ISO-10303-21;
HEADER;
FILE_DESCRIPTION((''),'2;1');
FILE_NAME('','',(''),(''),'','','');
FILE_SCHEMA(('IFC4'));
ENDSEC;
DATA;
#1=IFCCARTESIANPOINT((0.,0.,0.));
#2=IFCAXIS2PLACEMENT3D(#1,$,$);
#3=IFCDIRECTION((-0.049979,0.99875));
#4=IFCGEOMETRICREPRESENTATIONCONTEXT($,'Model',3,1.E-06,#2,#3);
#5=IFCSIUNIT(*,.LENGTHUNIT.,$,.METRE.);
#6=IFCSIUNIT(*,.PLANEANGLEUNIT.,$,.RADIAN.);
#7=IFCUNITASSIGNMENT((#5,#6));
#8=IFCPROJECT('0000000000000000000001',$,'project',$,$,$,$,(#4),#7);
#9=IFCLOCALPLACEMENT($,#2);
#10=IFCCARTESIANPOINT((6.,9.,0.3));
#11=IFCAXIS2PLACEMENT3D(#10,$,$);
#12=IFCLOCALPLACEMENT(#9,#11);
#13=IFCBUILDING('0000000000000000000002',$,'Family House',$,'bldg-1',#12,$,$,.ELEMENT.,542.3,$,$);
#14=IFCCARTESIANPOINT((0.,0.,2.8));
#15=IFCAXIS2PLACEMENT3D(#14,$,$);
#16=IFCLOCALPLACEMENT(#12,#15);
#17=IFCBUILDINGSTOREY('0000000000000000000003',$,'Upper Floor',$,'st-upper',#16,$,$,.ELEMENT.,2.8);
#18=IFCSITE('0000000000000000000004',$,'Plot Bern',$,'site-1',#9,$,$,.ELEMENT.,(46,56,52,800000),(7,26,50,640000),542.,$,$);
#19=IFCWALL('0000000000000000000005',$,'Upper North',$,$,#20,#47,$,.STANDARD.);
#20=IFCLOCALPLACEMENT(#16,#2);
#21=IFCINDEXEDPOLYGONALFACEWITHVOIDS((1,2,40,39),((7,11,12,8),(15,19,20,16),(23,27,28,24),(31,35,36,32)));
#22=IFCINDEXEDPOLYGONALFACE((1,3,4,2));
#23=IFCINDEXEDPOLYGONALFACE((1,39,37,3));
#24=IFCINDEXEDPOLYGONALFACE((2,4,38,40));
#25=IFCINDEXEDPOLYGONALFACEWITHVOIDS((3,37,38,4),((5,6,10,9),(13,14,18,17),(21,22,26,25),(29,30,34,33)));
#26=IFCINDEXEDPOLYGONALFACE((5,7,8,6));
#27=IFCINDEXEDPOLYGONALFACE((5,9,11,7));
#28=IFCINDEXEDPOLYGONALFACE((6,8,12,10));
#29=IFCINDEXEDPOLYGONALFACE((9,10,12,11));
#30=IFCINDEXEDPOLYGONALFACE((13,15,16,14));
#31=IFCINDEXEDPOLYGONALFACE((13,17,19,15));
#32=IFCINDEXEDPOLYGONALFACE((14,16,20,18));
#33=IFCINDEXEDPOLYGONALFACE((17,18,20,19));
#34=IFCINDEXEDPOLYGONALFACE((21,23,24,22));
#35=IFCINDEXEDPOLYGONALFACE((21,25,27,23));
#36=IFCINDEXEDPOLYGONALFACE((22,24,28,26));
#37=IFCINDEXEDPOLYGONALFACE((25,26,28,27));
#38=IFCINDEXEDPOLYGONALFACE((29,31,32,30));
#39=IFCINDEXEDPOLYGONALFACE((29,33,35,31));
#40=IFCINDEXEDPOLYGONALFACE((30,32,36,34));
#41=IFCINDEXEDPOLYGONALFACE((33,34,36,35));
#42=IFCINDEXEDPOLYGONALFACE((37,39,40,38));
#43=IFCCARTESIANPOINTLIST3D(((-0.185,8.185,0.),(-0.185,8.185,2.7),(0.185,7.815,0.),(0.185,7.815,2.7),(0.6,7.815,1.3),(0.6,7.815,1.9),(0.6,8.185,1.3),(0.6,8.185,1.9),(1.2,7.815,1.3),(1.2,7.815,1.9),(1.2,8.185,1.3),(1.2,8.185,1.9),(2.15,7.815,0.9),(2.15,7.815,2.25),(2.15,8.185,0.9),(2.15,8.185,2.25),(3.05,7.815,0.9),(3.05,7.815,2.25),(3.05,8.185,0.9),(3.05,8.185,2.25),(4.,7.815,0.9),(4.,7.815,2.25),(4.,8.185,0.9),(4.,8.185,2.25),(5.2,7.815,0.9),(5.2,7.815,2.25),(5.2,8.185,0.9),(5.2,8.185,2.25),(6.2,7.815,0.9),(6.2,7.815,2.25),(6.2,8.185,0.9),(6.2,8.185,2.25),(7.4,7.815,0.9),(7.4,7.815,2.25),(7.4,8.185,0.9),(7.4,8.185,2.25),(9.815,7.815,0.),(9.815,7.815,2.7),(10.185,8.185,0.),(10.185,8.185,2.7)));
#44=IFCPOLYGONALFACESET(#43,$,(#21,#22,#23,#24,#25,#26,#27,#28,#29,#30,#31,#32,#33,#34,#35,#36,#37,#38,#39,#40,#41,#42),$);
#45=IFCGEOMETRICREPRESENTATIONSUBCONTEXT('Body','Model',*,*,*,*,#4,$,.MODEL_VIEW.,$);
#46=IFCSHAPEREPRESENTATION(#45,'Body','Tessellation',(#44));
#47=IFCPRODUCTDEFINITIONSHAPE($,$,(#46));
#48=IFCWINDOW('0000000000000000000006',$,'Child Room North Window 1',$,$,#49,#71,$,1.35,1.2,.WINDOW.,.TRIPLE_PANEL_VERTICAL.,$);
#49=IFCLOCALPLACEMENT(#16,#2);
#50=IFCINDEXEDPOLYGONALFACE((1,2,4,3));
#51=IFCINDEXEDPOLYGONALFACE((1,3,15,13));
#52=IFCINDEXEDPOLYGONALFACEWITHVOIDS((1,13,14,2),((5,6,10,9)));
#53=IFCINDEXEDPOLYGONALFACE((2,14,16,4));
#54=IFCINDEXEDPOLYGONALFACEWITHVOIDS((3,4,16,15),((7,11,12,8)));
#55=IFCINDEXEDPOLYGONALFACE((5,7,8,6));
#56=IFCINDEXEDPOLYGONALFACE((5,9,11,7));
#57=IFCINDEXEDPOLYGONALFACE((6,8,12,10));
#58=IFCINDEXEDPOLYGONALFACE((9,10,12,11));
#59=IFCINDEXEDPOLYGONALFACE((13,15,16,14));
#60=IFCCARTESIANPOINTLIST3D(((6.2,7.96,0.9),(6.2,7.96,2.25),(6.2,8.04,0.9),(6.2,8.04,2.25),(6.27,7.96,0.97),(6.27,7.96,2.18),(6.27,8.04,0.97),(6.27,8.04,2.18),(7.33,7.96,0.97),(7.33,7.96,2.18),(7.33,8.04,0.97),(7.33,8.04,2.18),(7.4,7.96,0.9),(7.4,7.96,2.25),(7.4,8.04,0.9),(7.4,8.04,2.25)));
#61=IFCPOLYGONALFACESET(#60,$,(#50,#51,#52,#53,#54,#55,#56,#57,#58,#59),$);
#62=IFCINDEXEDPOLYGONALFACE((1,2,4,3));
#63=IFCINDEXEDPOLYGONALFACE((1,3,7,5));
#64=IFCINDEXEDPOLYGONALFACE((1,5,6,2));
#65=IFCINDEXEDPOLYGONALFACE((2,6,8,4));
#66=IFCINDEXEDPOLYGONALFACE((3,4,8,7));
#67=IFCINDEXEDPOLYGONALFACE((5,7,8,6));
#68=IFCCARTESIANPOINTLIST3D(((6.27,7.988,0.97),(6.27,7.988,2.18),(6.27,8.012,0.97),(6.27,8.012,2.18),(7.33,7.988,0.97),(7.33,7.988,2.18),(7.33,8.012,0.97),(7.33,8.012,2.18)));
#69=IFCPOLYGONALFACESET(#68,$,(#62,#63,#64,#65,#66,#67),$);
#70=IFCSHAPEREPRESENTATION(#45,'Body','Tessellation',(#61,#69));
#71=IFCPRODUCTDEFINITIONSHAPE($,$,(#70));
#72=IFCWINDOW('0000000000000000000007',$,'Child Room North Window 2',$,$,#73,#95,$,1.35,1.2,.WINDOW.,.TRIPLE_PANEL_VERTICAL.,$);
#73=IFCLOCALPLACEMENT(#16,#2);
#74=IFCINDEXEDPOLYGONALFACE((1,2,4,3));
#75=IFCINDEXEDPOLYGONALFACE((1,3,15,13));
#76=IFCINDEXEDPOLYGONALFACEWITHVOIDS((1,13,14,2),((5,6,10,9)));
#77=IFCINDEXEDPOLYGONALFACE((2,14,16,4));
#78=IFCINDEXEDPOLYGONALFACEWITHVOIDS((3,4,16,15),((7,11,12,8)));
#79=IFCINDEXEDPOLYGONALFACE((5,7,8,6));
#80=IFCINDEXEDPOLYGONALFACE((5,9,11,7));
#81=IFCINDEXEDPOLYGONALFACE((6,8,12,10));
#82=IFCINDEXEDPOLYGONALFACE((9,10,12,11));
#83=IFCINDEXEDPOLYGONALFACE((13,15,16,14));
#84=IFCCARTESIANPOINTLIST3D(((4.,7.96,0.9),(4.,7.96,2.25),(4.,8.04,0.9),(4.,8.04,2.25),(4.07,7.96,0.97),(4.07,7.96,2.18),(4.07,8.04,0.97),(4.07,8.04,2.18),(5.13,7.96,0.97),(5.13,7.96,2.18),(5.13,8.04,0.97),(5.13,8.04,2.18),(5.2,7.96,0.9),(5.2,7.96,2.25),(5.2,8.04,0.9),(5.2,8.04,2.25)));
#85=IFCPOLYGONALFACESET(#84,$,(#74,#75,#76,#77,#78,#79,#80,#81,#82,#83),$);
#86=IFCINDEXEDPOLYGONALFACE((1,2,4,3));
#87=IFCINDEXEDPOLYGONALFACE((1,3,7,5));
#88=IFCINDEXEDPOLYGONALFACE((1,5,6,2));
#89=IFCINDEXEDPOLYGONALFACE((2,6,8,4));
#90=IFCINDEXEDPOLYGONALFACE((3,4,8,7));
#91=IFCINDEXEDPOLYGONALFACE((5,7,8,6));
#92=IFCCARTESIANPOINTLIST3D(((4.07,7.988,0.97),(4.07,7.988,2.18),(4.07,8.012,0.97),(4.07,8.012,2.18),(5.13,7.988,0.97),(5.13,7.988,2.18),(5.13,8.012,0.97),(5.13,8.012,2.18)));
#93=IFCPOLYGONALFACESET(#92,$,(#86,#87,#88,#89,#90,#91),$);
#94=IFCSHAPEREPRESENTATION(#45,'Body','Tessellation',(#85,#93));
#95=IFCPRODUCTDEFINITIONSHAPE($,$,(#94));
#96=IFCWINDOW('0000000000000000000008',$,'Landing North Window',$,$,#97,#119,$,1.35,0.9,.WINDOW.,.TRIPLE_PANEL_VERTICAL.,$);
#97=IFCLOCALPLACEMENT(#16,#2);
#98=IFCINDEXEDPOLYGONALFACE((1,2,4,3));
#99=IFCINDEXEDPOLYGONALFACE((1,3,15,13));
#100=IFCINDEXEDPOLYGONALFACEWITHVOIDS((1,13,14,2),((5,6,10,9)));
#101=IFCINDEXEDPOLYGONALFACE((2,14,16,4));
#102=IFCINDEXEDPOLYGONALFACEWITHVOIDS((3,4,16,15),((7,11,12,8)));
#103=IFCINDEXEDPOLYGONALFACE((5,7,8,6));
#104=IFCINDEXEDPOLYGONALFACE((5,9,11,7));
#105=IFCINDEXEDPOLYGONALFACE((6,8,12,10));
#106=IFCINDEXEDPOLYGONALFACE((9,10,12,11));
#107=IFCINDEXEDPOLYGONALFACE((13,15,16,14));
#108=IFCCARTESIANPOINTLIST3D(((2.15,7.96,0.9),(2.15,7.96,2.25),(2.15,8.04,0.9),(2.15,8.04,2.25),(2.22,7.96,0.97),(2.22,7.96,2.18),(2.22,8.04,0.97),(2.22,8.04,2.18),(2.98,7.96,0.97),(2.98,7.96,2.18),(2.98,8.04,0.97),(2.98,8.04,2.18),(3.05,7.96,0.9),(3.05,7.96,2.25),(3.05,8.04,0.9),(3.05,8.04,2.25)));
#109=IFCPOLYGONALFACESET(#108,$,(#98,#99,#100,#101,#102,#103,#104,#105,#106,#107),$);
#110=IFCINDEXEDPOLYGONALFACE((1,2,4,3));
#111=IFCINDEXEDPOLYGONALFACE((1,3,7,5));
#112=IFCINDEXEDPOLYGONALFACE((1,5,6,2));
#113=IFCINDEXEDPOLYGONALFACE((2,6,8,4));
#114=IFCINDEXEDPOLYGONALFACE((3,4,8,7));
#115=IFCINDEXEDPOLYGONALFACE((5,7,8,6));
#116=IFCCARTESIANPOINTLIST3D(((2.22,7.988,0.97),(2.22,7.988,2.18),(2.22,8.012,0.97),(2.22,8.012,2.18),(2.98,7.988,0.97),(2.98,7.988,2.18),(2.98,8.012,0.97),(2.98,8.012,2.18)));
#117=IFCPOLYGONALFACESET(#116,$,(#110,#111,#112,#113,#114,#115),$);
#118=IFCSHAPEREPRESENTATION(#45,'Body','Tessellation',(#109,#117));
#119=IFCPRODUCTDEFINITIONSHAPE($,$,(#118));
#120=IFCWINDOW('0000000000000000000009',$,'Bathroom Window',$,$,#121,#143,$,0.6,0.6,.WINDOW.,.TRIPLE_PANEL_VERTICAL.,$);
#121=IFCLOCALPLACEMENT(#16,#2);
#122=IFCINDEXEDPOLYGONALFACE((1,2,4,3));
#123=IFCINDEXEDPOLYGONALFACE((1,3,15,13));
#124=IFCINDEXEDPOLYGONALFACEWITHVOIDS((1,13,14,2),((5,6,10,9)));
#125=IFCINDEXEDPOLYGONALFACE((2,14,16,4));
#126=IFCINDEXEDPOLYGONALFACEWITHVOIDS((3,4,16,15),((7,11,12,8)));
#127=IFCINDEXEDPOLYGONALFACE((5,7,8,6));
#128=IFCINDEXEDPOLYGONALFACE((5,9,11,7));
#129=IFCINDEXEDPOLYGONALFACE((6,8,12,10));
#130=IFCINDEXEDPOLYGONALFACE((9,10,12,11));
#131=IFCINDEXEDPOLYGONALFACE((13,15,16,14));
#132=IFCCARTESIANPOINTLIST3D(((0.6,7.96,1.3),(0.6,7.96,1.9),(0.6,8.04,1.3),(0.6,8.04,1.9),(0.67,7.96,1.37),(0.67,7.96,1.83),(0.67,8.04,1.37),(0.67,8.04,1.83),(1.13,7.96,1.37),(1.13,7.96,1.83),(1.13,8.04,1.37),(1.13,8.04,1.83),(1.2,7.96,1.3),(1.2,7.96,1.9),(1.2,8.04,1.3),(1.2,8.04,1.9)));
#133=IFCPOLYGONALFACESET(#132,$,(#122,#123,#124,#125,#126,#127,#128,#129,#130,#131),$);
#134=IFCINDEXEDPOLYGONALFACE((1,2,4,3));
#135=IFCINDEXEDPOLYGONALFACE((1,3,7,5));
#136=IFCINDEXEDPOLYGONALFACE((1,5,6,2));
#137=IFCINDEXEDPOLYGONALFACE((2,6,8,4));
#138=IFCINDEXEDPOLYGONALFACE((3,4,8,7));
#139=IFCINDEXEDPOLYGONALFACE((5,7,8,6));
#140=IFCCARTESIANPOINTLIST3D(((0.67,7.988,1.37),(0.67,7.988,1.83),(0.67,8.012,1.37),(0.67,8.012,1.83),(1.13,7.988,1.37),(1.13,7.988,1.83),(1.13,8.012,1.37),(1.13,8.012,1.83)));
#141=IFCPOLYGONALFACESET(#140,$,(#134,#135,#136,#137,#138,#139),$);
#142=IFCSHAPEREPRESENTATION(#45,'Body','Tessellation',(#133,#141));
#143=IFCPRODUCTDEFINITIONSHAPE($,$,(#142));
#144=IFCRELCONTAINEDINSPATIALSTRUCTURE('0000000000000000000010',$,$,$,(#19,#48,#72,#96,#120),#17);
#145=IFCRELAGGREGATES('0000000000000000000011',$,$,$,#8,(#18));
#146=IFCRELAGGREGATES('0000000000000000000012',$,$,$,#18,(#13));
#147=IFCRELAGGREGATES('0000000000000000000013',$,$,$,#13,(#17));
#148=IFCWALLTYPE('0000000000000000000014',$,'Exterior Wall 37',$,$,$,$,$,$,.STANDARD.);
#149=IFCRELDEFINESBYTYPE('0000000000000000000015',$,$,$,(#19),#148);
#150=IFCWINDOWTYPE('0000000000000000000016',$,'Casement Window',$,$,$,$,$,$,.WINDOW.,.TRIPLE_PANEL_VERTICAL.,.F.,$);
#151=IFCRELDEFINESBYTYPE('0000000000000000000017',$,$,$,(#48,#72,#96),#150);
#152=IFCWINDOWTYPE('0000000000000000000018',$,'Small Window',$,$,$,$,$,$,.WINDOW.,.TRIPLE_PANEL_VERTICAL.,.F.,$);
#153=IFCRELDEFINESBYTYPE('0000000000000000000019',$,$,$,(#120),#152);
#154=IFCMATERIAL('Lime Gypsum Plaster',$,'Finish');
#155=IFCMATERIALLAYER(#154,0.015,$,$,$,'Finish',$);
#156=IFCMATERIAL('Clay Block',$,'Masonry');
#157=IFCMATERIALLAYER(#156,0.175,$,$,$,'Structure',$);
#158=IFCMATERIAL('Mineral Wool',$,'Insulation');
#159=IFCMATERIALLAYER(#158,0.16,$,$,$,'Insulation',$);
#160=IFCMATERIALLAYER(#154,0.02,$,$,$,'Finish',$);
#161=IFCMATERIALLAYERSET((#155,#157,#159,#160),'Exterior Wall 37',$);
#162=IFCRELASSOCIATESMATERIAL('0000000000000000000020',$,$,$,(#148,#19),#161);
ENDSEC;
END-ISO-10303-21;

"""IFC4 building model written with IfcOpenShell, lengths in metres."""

from ifc_helpers import new_model, si_unit, direction, frame, frame_2d, origin, origin_2d, place, context, subcontext, project, spatial, polyline, rectangle, outline, extrude, material, layer, layer_set, layer_usage, type_object, element, fill, save


model = new_model("IFC4")

# Units and contexts
model_context = context("Model", 3, precision=1e-06, world=origin(), true_north=direction((-0.049979, 0.99875)))
body_context = subcontext(model_context, "Body", "Model", "MODEL_VIEW")
ifc_project = project(units=[si_unit("LENGTHUNIT", "METRE"), si_unit("PLANEANGLEUNIT", "RADIAN")], contexts=[model_context])

# Site, building, storey
site_placement = place(None, origin())
site = spatial("IfcSite", under=ifc_project, at=site_placement, Name="Plot Bern", ObjectType="site-1", CompositionType="ELEMENT", RefLatitude=(46, 56, 52, 800000), RefLongitude=(7, 26, 50, 640000), RefElevation=542.0)
building_placement = place(site_placement, frame((6.0, 9.0, 0.3)))
building = spatial("IfcBuilding", under=site, at=building_placement, Name="Family House", ObjectType="bldg-1", CompositionType="ELEMENT", ElevationOfRefHeight=542.3)
storey_placement = place(building_placement, frame((0.0, 0.0, 2.8)))
storey = spatial("IfcBuildingStorey", under=building, at=storey_placement, Name="Upper Floor", ObjectType="st-upper", CompositionType="ELEMENT", Elevation=2.8)

# Shared definitions
ifc_material_1 = material(Name="Mineral Wool", Category="Insulation")

# Shared definitions
ifc_material_2 = material(Name="Lime Gypsum Plaster", Category="Finish")
ifc_layer_1 = layer(ifc_material_2, 0.015, Category="Finish")
ifc_material_3 = material(Name="Clay Block", Category="Masonry")
ifc_layer_2 = layer(ifc_material_3, 0.175, Category="Structure")
ifc_layer_3 = layer(ifc_material_1, 0.16, Category="Insulation")
ifc_layer_4 = layer(ifc_material_2, 0.02, Category="Finish")
ifc_layer_set_1 = layer_set([ifc_layer_1, ifc_layer_2, ifc_layer_3, ifc_layer_4], Name="Exterior Wall 37")
wall_type_1 = type_object("IfcWallType", Name="Exterior Wall 37", PredefinedType="STANDARD", material=ifc_layer_set_1)

# Shared definitions
window_type_1 = type_object("IfcWindowType", Name="Casement Window", ParameterTakesPrecedence=False, PartitioningType="TRIPLE_PANEL_VERTICAL", PredefinedType="WINDOW")

# Wall, openings, windows
ifc_layer_usage_1 = layer_usage(ifc_layer_set_1, "AXIS2", "NEGATIVE", 0.185)
wall_1_placement = place(storey_placement, origin())
wall_1 = element("IfcWall", 1, at=wall_1_placement, inside=storey, type_object=wall_type_1, material=ifc_layer_usage_1, Name="Upper North", PredefinedType="STANDARD", context=body_context, shape_type="SweptSolid", body=[
    extrude(outline(polyline([(10.185, 8.185), (-0.185, 8.185), (0.185, 7.815), (9.815, 7.815), (10.185, 8.185)])), origin(), (0.0, 0.0, 1.0), 2.7),
])
opening_1_placement = place(wall_1_placement, frame((0.9, 8.0, 1.3), z_axis=(0.0, 0.0, 1.0), x_axis=(-1.0, 0.0, 0.0)))
opening_1 = element("IfcOpeningElement", 2, at=opening_1_placement, cuts=wall_1, PredefinedType="OPENING", context=body_context, shape_type="SweptSolid", body=[
    extrude(rectangle(XDim=0.6, YDim=0.37, at=origin_2d()), origin(), (0.0, 0.0, 1.0), 0.6),
])
opening_2_placement = place(wall_1_placement, frame((6.8, 8.0, 0.9), z_axis=(0.0, 0.0, 1.0), x_axis=(-1.0, 0.0, 0.0)))
opening_2 = element("IfcOpeningElement", 3, at=opening_2_placement, cuts=wall_1, PredefinedType="OPENING", context=body_context, shape_type="SweptSolid", body=[
    extrude(rectangle(XDim=1.2, YDim=0.37, at=origin_2d()), origin(), (0.0, 0.0, 1.0), 1.35),
])
opening_3_placement = place(wall_1_placement, frame((4.6, 8.0, 0.9), z_axis=(0.0, 0.0, 1.0), x_axis=(-1.0, 0.0, 0.0)))
opening_3 = element("IfcOpeningElement", 4, at=opening_3_placement, cuts=wall_1, PredefinedType="OPENING", context=body_context, shape_type="SweptSolid", body=[
    extrude(rectangle(XDim=1.2, YDim=0.37, at=origin_2d()), origin(), (0.0, 0.0, 1.0), 1.35),
])
opening_4_placement = place(wall_1_placement, frame((2.6, 8.0, 0.9), z_axis=(0.0, 0.0, 1.0), x_axis=(-1.0, 0.0, 0.0)))
opening_4 = element("IfcOpeningElement", 5, at=opening_4_placement, cuts=wall_1, PredefinedType="OPENING", context=body_context, shape_type="SweptSolid", body=[
    extrude(rectangle(XDim=0.9, YDim=0.37, at=origin_2d()), origin(), (0.0, 0.0, 1.0), 1.35),
])
window_1_placement = place(opening_2_placement, frame((0.0, 0.0, 0.0), z_axis=(0.0, -1.0, 0.0), x_axis=(1.0, 0.0, 0.0)))
window_1 = element("IfcWindow", 6, at=window_1_placement, inside=storey, type_object=window_type_1, Name="Child Room North Window 1", OverallHeight=1.35, OverallWidth=1.2, PartitioningType="TRIPLE_PANEL_VERTICAL", PredefinedType="WINDOW", context=body_context, shape_type="SweptSolid", body=[
    extrude(outline(polyline([(-0.6, 0.0), (0.6, 0.0), (0.6, 1.35), (-0.6, 1.35), (-0.6, 0.0)]), holes=[polyline([(-0.53, 0.07), (0.53, 0.07), (0.53, 1.28), (-0.53, 1.28), (-0.53, 0.07)])]), frame((0.0, 0.0, -0.04)), (0.0, 0.0, 1.0), 0.08),
    extrude(rectangle(XDim=1.06, YDim=1.21, at=frame_2d((0.0, 0.675))), frame((0.0, 0.0, -0.012)), (0.0, 0.0, 1.0), 0.024),
])
fill(opening_2, window_1)
window_2_placement = place(opening_3_placement, frame((0.0, 0.0, 0.0), z_axis=(0.0, -1.0, 0.0), x_axis=(1.0, 0.0, 0.0)))
window_2 = element("IfcWindow", 7, at=window_2_placement, inside=storey, type_object=window_type_1, Name="Child Room North Window 2", OverallHeight=1.35, OverallWidth=1.2, PartitioningType="TRIPLE_PANEL_VERTICAL", PredefinedType="WINDOW", context=body_context, shape_type="SweptSolid", body=[
    extrude(outline(polyline([(-0.6, 0.0), (0.6, 0.0), (0.6, 1.35), (-0.6, 1.35), (-0.6, 0.0)]), holes=[polyline([(-0.53, 0.07), (0.53, 0.07), (0.53, 1.28), (-0.53, 1.28), (-0.53, 0.07)])]), frame((0.0, 0.0, -0.04)), (0.0, 0.0, 1.0), 0.08),
    extrude(rectangle(XDim=1.06, YDim=1.21, at=frame_2d((0.0, 0.675))), frame((0.0, 0.0, -0.012)), (0.0, 0.0, 1.0), 0.024),
])
fill(opening_3, window_2)
window_3_placement = place(opening_4_placement, frame((0.0, 0.0, 0.0), z_axis=(0.0, -1.0, 0.0), x_axis=(1.0, 0.0, 0.0)))
window_3 = element("IfcWindow", 8, at=window_3_placement, inside=storey, type_object=window_type_1, Name="Landing North Window", OverallHeight=1.35, OverallWidth=0.9, PartitioningType="TRIPLE_PANEL_VERTICAL", PredefinedType="WINDOW", context=body_context, shape_type="SweptSolid", body=[
    extrude(outline(polyline([(-0.45, 0.0), (0.45, 0.0), (0.45, 1.35), (-0.45, 1.35), (-0.45, 0.0)]), holes=[polyline([(-0.38, 0.07), (0.38, 0.07), (0.38, 1.28), (-0.38, 1.28), (-0.38, 0.07)])]), frame((0.0, 0.0, -0.04)), (0.0, 0.0, 1.0), 0.08),
    extrude(rectangle(XDim=0.76, YDim=1.21, at=frame_2d((0.0, 0.675))), frame((0.0, 0.0, -0.012)), (0.0, 0.0, 1.0), 0.024),
])
fill(opening_4, window_3)
window_type_2 = type_object("IfcWindowType", Name="Small Window", ParameterTakesPrecedence=False, PartitioningType="TRIPLE_PANEL_VERTICAL", PredefinedType="WINDOW")
window_4_placement = place(opening_1_placement, frame((0.0, 0.0, 0.0), z_axis=(0.0, -1.0, 0.0), x_axis=(1.0, 0.0, 0.0)))
window_4 = element("IfcWindow", 9, at=window_4_placement, inside=storey, type_object=window_type_2, Name="Bathroom Window", OverallHeight=0.6, OverallWidth=0.6, PartitioningType="TRIPLE_PANEL_VERTICAL", PredefinedType="WINDOW", context=body_context, shape_type="SweptSolid", body=[
    extrude(outline(polyline([(-0.3, 0.0), (0.3, 0.0), (0.3, 0.6), (-0.3, 0.6), (-0.3, 0.0)]), holes=[polyline([(-0.23, 0.07), (0.23, 0.07), (0.23, 0.53), (-0.23, 0.53), (-0.23, 0.07)])]), frame((0.0, 0.0, -0.04)), (0.0, 0.0, 1.0), 0.08),
    extrude(rectangle(XDim=0.46, YDim=0.46, at=frame_2d((0.0, 0.3))), frame((0.0, 0.0, -0.012)), (0.0, 0.0, 1.0), 0.024),
])
fill(opening_1, window_4)

save(model, "model.ifc")
